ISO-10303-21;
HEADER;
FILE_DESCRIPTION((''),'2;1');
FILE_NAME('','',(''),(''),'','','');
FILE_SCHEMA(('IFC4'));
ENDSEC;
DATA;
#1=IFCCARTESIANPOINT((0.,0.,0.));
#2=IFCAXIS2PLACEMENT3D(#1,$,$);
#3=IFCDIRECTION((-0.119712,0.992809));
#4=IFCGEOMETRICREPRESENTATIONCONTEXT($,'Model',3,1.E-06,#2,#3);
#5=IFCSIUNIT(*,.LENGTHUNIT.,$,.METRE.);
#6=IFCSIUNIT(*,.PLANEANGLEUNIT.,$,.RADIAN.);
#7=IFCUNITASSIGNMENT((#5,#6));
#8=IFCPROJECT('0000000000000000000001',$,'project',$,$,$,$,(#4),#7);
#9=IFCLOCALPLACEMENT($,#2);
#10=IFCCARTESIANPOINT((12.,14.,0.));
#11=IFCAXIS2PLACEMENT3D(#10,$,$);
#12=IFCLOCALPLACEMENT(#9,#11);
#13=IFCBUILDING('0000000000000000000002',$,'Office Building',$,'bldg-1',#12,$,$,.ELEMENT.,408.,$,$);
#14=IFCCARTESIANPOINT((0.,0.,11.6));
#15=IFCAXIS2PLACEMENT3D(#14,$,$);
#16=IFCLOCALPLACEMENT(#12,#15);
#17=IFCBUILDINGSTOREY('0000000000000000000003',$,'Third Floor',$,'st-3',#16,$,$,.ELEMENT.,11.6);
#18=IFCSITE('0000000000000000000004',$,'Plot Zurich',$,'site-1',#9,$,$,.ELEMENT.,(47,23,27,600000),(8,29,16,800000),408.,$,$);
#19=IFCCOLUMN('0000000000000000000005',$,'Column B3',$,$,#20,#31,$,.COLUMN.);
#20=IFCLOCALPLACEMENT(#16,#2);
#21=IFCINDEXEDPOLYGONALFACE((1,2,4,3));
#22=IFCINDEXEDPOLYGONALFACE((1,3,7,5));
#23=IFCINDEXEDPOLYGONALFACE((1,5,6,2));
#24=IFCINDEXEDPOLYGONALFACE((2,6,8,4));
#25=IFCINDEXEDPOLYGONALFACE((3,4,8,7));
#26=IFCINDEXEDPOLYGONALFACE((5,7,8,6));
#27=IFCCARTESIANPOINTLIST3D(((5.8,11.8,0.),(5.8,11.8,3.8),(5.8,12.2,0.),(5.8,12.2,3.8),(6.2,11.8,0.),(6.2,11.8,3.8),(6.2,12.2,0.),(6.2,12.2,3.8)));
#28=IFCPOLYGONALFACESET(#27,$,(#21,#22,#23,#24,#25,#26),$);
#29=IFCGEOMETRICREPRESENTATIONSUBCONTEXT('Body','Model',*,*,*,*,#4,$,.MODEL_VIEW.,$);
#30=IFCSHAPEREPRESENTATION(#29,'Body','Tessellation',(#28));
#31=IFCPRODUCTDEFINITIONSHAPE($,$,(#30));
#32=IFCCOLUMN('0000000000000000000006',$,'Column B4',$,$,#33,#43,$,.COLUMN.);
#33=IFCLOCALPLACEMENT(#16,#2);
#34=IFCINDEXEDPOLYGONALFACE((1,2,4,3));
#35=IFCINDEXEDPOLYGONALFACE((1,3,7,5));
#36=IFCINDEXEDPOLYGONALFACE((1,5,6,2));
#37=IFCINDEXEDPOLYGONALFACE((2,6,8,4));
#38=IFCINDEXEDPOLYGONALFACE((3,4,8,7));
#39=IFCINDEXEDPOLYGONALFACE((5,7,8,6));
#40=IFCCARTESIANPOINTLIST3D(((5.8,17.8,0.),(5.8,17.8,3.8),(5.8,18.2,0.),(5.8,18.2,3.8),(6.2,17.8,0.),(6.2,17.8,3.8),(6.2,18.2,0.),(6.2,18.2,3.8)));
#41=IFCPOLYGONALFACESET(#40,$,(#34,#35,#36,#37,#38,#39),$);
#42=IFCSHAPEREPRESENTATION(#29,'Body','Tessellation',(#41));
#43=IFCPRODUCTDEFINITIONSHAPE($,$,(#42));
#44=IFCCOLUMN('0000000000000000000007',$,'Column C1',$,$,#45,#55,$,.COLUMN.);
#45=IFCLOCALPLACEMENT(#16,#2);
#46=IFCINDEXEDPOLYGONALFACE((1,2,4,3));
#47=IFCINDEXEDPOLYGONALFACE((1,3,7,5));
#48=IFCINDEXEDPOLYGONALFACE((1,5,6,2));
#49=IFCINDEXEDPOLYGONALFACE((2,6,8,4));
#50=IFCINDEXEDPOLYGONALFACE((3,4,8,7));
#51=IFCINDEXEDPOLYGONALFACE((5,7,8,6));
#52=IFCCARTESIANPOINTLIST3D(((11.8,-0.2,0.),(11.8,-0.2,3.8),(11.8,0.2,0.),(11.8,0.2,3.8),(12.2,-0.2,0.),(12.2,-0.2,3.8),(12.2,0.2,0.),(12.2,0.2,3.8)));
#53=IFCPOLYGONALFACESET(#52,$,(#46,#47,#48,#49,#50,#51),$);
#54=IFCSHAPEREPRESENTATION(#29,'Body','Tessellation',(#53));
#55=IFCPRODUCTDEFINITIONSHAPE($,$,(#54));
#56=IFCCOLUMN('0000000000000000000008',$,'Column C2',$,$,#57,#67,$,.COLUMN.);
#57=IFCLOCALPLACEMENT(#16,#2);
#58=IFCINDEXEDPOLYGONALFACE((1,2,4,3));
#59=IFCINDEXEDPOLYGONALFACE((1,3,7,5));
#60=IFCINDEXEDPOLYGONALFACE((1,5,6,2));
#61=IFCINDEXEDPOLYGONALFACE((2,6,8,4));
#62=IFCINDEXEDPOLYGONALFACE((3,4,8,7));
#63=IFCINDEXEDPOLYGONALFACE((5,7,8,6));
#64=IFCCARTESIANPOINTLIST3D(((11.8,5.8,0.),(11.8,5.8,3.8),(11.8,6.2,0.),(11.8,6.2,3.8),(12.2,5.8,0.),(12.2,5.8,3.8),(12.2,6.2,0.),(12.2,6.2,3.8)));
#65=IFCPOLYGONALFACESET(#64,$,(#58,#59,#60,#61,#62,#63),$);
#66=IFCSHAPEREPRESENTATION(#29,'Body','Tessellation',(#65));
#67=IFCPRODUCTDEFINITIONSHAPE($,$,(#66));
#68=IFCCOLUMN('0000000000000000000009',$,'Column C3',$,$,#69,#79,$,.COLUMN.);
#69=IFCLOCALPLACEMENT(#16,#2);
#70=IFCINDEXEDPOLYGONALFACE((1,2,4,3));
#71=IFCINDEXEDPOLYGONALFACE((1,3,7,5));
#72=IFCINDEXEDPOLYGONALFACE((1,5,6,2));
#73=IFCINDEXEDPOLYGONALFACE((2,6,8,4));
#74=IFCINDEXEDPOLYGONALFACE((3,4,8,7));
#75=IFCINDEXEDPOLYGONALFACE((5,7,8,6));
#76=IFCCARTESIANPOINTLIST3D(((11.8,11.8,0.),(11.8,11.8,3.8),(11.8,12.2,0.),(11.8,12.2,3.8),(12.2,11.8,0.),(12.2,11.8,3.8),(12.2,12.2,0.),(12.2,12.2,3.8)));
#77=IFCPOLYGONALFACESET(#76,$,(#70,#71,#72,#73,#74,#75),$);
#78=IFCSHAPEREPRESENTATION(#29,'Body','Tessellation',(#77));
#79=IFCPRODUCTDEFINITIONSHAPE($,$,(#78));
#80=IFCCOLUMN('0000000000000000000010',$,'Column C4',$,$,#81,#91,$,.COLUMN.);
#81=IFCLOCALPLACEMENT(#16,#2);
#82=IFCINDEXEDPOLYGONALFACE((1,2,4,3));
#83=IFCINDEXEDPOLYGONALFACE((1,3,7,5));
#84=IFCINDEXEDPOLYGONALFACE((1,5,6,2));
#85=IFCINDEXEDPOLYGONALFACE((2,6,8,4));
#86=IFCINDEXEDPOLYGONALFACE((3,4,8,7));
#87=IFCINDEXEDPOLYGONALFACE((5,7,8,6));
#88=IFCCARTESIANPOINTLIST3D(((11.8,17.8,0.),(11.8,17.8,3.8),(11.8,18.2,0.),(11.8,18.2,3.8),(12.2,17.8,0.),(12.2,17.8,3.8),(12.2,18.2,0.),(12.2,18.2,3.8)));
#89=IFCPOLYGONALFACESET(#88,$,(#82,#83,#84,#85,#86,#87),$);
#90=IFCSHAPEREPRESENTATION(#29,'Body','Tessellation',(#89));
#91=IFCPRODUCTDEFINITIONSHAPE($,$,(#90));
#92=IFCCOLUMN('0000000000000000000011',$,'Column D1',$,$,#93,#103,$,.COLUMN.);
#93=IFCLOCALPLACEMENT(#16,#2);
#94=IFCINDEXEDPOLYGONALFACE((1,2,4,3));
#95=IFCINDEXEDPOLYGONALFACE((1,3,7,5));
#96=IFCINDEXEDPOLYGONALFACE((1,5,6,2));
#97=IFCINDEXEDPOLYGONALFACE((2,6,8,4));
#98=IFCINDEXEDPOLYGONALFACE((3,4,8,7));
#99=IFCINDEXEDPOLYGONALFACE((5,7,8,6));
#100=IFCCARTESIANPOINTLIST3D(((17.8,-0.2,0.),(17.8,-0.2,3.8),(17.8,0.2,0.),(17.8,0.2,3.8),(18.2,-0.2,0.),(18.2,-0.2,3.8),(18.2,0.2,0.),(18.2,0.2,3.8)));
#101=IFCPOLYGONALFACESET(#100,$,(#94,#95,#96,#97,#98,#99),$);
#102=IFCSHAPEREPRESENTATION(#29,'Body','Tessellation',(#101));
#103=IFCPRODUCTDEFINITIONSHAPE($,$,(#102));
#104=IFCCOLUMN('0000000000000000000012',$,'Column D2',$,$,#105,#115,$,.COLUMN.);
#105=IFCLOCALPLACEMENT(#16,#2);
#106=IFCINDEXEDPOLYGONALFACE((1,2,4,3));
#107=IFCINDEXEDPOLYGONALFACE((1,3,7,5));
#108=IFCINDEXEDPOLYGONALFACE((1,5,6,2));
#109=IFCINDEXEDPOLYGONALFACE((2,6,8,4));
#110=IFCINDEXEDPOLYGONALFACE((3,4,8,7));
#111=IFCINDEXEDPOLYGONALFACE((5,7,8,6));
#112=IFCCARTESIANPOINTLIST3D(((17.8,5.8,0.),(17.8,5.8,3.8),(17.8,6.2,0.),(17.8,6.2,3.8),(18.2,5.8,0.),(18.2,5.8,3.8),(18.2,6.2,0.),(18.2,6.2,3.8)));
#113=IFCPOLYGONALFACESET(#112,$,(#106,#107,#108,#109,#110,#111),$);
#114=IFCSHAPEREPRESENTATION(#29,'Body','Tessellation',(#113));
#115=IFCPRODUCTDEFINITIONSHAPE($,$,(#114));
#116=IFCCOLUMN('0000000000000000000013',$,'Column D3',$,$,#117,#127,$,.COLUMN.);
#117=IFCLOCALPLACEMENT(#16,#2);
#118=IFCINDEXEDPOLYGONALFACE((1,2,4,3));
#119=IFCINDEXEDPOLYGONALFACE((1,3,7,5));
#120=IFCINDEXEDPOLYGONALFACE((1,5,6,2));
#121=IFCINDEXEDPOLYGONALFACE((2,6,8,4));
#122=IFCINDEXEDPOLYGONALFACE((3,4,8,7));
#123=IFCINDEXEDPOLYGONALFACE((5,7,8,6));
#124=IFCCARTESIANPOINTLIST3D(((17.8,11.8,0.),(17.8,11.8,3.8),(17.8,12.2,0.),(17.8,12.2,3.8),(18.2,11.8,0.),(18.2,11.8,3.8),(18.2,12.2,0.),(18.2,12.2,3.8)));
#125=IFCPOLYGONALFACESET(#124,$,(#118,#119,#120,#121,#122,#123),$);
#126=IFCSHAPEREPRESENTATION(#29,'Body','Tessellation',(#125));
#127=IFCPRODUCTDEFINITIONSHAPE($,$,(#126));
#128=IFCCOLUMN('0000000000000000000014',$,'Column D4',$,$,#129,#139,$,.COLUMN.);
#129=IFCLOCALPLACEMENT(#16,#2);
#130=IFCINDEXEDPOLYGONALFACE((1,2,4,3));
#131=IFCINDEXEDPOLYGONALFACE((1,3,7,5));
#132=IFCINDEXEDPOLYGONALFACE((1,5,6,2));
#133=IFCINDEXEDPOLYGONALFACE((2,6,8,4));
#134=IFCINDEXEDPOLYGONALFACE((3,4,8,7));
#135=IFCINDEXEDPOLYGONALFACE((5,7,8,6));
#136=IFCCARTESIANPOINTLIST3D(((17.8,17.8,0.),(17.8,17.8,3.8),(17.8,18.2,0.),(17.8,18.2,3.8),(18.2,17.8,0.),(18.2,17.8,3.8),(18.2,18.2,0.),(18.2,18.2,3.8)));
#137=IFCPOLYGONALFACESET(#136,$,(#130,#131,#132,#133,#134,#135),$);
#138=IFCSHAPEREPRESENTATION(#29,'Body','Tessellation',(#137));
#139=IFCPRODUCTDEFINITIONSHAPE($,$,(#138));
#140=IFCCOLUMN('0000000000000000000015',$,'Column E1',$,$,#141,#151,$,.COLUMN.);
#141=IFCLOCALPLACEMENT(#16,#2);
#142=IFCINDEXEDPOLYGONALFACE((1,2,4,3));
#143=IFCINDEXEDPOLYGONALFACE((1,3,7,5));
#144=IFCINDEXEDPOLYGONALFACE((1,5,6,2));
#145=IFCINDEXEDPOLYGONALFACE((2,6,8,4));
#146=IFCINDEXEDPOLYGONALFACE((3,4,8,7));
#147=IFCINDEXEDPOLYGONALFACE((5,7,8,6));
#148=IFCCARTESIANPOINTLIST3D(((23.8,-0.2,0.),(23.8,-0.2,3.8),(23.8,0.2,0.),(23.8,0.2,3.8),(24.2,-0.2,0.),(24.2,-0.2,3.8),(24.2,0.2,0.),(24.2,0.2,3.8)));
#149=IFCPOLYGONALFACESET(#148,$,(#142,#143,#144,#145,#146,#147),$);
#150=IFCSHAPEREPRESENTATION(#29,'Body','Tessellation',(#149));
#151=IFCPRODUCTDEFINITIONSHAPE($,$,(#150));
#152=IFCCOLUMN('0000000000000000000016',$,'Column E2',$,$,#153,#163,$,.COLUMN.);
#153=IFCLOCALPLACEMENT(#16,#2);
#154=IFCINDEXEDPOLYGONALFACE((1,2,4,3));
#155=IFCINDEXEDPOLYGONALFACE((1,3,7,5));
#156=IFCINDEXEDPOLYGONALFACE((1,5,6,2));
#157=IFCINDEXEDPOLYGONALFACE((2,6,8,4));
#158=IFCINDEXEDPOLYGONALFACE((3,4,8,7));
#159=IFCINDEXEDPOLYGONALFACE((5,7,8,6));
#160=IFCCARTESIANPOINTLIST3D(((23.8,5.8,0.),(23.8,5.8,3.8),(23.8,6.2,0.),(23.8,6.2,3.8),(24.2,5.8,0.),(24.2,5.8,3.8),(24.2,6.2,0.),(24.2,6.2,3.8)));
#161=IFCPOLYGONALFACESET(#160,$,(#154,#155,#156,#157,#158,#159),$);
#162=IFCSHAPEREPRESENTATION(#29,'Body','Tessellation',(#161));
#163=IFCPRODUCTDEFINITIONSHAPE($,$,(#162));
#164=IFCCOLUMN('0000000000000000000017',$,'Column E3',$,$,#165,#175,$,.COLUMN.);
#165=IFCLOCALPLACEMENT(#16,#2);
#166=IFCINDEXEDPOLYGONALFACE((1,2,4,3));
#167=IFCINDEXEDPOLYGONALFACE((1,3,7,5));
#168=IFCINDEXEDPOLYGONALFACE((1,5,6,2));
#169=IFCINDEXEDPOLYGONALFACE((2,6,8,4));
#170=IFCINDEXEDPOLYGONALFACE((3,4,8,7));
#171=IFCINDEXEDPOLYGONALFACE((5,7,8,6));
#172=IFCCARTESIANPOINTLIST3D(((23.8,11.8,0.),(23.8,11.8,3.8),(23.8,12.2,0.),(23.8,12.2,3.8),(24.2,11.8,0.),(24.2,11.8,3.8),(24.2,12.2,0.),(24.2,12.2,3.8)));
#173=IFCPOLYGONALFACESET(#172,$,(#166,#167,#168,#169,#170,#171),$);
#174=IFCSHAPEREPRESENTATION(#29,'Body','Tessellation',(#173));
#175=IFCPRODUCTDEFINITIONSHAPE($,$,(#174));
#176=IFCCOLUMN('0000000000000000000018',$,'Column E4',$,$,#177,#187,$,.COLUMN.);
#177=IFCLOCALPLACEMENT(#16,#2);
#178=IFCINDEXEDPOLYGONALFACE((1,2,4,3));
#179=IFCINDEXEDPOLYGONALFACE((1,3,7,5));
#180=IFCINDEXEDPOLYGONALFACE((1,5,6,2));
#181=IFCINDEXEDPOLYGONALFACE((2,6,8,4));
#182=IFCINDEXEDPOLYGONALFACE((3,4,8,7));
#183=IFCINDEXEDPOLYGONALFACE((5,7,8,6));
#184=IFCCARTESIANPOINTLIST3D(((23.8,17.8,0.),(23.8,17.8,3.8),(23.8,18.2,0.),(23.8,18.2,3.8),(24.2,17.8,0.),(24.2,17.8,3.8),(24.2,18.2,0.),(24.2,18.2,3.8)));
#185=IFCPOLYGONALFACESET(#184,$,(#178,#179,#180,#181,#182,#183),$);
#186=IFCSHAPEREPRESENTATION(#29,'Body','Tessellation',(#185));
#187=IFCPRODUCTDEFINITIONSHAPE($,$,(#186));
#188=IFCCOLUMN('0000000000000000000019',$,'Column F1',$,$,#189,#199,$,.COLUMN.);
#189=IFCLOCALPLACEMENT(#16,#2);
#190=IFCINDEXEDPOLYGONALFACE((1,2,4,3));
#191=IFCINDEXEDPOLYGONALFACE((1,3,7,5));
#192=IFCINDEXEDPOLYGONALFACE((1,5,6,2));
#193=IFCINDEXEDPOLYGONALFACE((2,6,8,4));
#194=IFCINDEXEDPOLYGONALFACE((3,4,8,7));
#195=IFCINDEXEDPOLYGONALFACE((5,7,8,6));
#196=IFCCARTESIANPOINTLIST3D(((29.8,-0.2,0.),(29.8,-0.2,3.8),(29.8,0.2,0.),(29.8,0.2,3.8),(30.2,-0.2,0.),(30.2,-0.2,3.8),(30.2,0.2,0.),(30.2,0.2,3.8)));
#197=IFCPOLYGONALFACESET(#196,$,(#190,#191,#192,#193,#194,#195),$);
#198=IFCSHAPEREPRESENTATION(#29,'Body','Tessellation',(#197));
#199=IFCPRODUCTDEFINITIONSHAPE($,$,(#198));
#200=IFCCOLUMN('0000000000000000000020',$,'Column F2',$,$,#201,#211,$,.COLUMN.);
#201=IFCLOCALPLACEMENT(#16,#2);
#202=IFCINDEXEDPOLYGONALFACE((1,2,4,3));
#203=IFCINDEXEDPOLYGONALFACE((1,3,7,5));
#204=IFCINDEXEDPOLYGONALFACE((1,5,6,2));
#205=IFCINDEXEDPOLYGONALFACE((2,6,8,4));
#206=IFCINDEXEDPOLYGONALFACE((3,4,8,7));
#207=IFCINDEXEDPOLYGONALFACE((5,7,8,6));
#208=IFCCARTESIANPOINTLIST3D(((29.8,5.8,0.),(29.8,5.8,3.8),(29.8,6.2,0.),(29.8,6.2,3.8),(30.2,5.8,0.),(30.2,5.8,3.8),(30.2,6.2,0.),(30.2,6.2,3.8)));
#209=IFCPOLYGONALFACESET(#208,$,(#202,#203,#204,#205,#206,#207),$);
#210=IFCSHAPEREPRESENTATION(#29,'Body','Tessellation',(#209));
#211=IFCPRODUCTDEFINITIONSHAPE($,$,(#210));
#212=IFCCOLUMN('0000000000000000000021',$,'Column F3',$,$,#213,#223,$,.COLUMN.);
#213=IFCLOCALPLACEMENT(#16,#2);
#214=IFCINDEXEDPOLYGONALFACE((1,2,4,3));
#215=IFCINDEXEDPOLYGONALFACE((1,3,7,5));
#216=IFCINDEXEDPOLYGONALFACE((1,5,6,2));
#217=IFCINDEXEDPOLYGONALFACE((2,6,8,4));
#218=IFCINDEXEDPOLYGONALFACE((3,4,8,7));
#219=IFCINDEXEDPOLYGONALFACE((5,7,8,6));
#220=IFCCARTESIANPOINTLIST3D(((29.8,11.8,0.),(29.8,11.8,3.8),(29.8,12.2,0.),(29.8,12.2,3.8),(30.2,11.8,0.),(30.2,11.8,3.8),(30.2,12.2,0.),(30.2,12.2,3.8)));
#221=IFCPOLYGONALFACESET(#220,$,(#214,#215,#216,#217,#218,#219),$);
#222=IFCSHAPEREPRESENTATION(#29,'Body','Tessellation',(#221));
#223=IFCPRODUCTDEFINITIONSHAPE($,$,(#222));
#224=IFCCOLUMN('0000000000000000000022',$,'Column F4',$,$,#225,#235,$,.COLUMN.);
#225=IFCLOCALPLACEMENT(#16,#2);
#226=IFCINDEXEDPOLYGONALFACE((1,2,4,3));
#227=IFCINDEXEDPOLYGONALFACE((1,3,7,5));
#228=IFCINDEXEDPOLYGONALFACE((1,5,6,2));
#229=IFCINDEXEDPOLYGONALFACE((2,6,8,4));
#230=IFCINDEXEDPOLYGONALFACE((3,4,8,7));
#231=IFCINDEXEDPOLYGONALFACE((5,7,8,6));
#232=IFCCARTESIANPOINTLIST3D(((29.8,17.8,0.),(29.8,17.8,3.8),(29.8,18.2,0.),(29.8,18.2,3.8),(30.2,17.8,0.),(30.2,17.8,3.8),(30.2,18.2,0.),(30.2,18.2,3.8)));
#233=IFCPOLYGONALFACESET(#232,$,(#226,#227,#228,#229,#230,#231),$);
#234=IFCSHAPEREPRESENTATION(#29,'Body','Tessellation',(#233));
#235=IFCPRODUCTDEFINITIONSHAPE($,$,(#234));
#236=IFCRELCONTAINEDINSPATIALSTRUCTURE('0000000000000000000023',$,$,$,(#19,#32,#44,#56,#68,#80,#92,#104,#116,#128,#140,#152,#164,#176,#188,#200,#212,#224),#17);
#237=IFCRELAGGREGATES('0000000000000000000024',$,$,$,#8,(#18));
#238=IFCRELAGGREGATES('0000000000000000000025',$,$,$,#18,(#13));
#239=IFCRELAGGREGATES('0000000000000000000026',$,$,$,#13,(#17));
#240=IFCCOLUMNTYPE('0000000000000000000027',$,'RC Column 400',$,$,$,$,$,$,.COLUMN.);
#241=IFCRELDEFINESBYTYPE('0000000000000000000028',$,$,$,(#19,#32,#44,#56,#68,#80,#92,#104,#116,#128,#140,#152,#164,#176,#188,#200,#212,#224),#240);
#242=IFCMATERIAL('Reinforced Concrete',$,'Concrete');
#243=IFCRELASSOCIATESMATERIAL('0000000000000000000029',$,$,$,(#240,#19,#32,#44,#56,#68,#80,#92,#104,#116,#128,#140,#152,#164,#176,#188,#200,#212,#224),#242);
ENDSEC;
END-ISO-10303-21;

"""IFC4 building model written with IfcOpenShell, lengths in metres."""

from ifc_helpers import new_model, si_unit, direction, frame, origin, origin_2d, place, context, subcontext, project, spatial, rectangle, extrude, material, type_object, element, save


model = new_model("IFC4")

# Units and contexts
model_context = context("Model", 3, precision=1e-06, world=origin(), true_north=direction((-0.119712, 0.992809)))
body_context = subcontext(model_context, "Body", "Model", "MODEL_VIEW")
ifc_project = project(units=[si_unit("LENGTHUNIT", "METRE"), si_unit("PLANEANGLEUNIT", "RADIAN")], contexts=[model_context])

# Site, building, storey
site_placement = place(None, origin())
site = spatial("IfcSite", under=ifc_project, at=site_placement, Name="Plot Zurich", ObjectType="site-1", CompositionType="ELEMENT", RefLatitude=(47, 23, 27, 600000), RefLongitude=(8, 29, 16, 800000), RefElevation=408.0)
building_placement = place(site_placement, frame((12.0, 14.0, 0.0)))
building = spatial("IfcBuilding", under=site, at=building_placement, Name="Office Building", ObjectType="bldg-1", CompositionType="ELEMENT", ElevationOfRefHeight=408.0)
storey_placement = place(building_placement, frame((0.0, 0.0, 11.6)))
storey = spatial("IfcBuildingStorey", under=building, at=storey_placement, Name="Third Floor", ObjectType="st-3", CompositionType="ELEMENT", Elevation=11.6)

# Columns
ifc_material_1 = material(Name="Reinforced Concrete", Category="Concrete")
column_type = type_object("IfcColumnType", Name="RC Column 400", PredefinedType="COLUMN", material=ifc_material_1)
for number, where, name in (
    (1, (6.0, 12.0, 0.0), "Column B3"),
    (2, (6.0, 18.0, 0.0), "Column B4"),
    (3, (12.0, 0.0, 0.0), "Column C1"),
    (4, (12.0, 6.0, 0.0), "Column C2"),
    (5, (12.0, 12.0, 0.0), "Column C3"),
    (6, (12.0, 18.0, 0.0), "Column C4"),
    (7, (18.0, 0.0, 0.0), "Column D1"),
    (8, (18.0, 6.0, 0.0), "Column D2"),
    (9, (18.0, 12.0, 0.0), "Column D3"),
    (10, (18.0, 18.0, 0.0), "Column D4"),
    (11, (24.0, 0.0, 0.0), "Column E1"),
    (12, (24.0, 6.0, 0.0), "Column E2"),
    (13, (24.0, 12.0, 0.0), "Column E3"),
    (14, (24.0, 18.0, 0.0), "Column E4"),
    (15, (30.0, 0.0, 0.0), "Column F1"),
    (16, (30.0, 6.0, 0.0), "Column F2"),
    (17, (30.0, 12.0, 0.0), "Column F3"),
    (18, (30.0, 18.0, 0.0), "Column F4"),
):
    element("IfcColumn", number, at=place(storey_placement, frame(where)), inside=storey, type_object=column_type, material=ifc_material_1, Name=name, PredefinedType="COLUMN", context=body_context, shape_type="SweptSolid", body=[
        extrude(rectangle(XDim=0.4, YDim=0.4, at=origin_2d()), origin(), (0.0, 0.0, 1.0), 3.8),
    ])

save(model, "model.ifc")
